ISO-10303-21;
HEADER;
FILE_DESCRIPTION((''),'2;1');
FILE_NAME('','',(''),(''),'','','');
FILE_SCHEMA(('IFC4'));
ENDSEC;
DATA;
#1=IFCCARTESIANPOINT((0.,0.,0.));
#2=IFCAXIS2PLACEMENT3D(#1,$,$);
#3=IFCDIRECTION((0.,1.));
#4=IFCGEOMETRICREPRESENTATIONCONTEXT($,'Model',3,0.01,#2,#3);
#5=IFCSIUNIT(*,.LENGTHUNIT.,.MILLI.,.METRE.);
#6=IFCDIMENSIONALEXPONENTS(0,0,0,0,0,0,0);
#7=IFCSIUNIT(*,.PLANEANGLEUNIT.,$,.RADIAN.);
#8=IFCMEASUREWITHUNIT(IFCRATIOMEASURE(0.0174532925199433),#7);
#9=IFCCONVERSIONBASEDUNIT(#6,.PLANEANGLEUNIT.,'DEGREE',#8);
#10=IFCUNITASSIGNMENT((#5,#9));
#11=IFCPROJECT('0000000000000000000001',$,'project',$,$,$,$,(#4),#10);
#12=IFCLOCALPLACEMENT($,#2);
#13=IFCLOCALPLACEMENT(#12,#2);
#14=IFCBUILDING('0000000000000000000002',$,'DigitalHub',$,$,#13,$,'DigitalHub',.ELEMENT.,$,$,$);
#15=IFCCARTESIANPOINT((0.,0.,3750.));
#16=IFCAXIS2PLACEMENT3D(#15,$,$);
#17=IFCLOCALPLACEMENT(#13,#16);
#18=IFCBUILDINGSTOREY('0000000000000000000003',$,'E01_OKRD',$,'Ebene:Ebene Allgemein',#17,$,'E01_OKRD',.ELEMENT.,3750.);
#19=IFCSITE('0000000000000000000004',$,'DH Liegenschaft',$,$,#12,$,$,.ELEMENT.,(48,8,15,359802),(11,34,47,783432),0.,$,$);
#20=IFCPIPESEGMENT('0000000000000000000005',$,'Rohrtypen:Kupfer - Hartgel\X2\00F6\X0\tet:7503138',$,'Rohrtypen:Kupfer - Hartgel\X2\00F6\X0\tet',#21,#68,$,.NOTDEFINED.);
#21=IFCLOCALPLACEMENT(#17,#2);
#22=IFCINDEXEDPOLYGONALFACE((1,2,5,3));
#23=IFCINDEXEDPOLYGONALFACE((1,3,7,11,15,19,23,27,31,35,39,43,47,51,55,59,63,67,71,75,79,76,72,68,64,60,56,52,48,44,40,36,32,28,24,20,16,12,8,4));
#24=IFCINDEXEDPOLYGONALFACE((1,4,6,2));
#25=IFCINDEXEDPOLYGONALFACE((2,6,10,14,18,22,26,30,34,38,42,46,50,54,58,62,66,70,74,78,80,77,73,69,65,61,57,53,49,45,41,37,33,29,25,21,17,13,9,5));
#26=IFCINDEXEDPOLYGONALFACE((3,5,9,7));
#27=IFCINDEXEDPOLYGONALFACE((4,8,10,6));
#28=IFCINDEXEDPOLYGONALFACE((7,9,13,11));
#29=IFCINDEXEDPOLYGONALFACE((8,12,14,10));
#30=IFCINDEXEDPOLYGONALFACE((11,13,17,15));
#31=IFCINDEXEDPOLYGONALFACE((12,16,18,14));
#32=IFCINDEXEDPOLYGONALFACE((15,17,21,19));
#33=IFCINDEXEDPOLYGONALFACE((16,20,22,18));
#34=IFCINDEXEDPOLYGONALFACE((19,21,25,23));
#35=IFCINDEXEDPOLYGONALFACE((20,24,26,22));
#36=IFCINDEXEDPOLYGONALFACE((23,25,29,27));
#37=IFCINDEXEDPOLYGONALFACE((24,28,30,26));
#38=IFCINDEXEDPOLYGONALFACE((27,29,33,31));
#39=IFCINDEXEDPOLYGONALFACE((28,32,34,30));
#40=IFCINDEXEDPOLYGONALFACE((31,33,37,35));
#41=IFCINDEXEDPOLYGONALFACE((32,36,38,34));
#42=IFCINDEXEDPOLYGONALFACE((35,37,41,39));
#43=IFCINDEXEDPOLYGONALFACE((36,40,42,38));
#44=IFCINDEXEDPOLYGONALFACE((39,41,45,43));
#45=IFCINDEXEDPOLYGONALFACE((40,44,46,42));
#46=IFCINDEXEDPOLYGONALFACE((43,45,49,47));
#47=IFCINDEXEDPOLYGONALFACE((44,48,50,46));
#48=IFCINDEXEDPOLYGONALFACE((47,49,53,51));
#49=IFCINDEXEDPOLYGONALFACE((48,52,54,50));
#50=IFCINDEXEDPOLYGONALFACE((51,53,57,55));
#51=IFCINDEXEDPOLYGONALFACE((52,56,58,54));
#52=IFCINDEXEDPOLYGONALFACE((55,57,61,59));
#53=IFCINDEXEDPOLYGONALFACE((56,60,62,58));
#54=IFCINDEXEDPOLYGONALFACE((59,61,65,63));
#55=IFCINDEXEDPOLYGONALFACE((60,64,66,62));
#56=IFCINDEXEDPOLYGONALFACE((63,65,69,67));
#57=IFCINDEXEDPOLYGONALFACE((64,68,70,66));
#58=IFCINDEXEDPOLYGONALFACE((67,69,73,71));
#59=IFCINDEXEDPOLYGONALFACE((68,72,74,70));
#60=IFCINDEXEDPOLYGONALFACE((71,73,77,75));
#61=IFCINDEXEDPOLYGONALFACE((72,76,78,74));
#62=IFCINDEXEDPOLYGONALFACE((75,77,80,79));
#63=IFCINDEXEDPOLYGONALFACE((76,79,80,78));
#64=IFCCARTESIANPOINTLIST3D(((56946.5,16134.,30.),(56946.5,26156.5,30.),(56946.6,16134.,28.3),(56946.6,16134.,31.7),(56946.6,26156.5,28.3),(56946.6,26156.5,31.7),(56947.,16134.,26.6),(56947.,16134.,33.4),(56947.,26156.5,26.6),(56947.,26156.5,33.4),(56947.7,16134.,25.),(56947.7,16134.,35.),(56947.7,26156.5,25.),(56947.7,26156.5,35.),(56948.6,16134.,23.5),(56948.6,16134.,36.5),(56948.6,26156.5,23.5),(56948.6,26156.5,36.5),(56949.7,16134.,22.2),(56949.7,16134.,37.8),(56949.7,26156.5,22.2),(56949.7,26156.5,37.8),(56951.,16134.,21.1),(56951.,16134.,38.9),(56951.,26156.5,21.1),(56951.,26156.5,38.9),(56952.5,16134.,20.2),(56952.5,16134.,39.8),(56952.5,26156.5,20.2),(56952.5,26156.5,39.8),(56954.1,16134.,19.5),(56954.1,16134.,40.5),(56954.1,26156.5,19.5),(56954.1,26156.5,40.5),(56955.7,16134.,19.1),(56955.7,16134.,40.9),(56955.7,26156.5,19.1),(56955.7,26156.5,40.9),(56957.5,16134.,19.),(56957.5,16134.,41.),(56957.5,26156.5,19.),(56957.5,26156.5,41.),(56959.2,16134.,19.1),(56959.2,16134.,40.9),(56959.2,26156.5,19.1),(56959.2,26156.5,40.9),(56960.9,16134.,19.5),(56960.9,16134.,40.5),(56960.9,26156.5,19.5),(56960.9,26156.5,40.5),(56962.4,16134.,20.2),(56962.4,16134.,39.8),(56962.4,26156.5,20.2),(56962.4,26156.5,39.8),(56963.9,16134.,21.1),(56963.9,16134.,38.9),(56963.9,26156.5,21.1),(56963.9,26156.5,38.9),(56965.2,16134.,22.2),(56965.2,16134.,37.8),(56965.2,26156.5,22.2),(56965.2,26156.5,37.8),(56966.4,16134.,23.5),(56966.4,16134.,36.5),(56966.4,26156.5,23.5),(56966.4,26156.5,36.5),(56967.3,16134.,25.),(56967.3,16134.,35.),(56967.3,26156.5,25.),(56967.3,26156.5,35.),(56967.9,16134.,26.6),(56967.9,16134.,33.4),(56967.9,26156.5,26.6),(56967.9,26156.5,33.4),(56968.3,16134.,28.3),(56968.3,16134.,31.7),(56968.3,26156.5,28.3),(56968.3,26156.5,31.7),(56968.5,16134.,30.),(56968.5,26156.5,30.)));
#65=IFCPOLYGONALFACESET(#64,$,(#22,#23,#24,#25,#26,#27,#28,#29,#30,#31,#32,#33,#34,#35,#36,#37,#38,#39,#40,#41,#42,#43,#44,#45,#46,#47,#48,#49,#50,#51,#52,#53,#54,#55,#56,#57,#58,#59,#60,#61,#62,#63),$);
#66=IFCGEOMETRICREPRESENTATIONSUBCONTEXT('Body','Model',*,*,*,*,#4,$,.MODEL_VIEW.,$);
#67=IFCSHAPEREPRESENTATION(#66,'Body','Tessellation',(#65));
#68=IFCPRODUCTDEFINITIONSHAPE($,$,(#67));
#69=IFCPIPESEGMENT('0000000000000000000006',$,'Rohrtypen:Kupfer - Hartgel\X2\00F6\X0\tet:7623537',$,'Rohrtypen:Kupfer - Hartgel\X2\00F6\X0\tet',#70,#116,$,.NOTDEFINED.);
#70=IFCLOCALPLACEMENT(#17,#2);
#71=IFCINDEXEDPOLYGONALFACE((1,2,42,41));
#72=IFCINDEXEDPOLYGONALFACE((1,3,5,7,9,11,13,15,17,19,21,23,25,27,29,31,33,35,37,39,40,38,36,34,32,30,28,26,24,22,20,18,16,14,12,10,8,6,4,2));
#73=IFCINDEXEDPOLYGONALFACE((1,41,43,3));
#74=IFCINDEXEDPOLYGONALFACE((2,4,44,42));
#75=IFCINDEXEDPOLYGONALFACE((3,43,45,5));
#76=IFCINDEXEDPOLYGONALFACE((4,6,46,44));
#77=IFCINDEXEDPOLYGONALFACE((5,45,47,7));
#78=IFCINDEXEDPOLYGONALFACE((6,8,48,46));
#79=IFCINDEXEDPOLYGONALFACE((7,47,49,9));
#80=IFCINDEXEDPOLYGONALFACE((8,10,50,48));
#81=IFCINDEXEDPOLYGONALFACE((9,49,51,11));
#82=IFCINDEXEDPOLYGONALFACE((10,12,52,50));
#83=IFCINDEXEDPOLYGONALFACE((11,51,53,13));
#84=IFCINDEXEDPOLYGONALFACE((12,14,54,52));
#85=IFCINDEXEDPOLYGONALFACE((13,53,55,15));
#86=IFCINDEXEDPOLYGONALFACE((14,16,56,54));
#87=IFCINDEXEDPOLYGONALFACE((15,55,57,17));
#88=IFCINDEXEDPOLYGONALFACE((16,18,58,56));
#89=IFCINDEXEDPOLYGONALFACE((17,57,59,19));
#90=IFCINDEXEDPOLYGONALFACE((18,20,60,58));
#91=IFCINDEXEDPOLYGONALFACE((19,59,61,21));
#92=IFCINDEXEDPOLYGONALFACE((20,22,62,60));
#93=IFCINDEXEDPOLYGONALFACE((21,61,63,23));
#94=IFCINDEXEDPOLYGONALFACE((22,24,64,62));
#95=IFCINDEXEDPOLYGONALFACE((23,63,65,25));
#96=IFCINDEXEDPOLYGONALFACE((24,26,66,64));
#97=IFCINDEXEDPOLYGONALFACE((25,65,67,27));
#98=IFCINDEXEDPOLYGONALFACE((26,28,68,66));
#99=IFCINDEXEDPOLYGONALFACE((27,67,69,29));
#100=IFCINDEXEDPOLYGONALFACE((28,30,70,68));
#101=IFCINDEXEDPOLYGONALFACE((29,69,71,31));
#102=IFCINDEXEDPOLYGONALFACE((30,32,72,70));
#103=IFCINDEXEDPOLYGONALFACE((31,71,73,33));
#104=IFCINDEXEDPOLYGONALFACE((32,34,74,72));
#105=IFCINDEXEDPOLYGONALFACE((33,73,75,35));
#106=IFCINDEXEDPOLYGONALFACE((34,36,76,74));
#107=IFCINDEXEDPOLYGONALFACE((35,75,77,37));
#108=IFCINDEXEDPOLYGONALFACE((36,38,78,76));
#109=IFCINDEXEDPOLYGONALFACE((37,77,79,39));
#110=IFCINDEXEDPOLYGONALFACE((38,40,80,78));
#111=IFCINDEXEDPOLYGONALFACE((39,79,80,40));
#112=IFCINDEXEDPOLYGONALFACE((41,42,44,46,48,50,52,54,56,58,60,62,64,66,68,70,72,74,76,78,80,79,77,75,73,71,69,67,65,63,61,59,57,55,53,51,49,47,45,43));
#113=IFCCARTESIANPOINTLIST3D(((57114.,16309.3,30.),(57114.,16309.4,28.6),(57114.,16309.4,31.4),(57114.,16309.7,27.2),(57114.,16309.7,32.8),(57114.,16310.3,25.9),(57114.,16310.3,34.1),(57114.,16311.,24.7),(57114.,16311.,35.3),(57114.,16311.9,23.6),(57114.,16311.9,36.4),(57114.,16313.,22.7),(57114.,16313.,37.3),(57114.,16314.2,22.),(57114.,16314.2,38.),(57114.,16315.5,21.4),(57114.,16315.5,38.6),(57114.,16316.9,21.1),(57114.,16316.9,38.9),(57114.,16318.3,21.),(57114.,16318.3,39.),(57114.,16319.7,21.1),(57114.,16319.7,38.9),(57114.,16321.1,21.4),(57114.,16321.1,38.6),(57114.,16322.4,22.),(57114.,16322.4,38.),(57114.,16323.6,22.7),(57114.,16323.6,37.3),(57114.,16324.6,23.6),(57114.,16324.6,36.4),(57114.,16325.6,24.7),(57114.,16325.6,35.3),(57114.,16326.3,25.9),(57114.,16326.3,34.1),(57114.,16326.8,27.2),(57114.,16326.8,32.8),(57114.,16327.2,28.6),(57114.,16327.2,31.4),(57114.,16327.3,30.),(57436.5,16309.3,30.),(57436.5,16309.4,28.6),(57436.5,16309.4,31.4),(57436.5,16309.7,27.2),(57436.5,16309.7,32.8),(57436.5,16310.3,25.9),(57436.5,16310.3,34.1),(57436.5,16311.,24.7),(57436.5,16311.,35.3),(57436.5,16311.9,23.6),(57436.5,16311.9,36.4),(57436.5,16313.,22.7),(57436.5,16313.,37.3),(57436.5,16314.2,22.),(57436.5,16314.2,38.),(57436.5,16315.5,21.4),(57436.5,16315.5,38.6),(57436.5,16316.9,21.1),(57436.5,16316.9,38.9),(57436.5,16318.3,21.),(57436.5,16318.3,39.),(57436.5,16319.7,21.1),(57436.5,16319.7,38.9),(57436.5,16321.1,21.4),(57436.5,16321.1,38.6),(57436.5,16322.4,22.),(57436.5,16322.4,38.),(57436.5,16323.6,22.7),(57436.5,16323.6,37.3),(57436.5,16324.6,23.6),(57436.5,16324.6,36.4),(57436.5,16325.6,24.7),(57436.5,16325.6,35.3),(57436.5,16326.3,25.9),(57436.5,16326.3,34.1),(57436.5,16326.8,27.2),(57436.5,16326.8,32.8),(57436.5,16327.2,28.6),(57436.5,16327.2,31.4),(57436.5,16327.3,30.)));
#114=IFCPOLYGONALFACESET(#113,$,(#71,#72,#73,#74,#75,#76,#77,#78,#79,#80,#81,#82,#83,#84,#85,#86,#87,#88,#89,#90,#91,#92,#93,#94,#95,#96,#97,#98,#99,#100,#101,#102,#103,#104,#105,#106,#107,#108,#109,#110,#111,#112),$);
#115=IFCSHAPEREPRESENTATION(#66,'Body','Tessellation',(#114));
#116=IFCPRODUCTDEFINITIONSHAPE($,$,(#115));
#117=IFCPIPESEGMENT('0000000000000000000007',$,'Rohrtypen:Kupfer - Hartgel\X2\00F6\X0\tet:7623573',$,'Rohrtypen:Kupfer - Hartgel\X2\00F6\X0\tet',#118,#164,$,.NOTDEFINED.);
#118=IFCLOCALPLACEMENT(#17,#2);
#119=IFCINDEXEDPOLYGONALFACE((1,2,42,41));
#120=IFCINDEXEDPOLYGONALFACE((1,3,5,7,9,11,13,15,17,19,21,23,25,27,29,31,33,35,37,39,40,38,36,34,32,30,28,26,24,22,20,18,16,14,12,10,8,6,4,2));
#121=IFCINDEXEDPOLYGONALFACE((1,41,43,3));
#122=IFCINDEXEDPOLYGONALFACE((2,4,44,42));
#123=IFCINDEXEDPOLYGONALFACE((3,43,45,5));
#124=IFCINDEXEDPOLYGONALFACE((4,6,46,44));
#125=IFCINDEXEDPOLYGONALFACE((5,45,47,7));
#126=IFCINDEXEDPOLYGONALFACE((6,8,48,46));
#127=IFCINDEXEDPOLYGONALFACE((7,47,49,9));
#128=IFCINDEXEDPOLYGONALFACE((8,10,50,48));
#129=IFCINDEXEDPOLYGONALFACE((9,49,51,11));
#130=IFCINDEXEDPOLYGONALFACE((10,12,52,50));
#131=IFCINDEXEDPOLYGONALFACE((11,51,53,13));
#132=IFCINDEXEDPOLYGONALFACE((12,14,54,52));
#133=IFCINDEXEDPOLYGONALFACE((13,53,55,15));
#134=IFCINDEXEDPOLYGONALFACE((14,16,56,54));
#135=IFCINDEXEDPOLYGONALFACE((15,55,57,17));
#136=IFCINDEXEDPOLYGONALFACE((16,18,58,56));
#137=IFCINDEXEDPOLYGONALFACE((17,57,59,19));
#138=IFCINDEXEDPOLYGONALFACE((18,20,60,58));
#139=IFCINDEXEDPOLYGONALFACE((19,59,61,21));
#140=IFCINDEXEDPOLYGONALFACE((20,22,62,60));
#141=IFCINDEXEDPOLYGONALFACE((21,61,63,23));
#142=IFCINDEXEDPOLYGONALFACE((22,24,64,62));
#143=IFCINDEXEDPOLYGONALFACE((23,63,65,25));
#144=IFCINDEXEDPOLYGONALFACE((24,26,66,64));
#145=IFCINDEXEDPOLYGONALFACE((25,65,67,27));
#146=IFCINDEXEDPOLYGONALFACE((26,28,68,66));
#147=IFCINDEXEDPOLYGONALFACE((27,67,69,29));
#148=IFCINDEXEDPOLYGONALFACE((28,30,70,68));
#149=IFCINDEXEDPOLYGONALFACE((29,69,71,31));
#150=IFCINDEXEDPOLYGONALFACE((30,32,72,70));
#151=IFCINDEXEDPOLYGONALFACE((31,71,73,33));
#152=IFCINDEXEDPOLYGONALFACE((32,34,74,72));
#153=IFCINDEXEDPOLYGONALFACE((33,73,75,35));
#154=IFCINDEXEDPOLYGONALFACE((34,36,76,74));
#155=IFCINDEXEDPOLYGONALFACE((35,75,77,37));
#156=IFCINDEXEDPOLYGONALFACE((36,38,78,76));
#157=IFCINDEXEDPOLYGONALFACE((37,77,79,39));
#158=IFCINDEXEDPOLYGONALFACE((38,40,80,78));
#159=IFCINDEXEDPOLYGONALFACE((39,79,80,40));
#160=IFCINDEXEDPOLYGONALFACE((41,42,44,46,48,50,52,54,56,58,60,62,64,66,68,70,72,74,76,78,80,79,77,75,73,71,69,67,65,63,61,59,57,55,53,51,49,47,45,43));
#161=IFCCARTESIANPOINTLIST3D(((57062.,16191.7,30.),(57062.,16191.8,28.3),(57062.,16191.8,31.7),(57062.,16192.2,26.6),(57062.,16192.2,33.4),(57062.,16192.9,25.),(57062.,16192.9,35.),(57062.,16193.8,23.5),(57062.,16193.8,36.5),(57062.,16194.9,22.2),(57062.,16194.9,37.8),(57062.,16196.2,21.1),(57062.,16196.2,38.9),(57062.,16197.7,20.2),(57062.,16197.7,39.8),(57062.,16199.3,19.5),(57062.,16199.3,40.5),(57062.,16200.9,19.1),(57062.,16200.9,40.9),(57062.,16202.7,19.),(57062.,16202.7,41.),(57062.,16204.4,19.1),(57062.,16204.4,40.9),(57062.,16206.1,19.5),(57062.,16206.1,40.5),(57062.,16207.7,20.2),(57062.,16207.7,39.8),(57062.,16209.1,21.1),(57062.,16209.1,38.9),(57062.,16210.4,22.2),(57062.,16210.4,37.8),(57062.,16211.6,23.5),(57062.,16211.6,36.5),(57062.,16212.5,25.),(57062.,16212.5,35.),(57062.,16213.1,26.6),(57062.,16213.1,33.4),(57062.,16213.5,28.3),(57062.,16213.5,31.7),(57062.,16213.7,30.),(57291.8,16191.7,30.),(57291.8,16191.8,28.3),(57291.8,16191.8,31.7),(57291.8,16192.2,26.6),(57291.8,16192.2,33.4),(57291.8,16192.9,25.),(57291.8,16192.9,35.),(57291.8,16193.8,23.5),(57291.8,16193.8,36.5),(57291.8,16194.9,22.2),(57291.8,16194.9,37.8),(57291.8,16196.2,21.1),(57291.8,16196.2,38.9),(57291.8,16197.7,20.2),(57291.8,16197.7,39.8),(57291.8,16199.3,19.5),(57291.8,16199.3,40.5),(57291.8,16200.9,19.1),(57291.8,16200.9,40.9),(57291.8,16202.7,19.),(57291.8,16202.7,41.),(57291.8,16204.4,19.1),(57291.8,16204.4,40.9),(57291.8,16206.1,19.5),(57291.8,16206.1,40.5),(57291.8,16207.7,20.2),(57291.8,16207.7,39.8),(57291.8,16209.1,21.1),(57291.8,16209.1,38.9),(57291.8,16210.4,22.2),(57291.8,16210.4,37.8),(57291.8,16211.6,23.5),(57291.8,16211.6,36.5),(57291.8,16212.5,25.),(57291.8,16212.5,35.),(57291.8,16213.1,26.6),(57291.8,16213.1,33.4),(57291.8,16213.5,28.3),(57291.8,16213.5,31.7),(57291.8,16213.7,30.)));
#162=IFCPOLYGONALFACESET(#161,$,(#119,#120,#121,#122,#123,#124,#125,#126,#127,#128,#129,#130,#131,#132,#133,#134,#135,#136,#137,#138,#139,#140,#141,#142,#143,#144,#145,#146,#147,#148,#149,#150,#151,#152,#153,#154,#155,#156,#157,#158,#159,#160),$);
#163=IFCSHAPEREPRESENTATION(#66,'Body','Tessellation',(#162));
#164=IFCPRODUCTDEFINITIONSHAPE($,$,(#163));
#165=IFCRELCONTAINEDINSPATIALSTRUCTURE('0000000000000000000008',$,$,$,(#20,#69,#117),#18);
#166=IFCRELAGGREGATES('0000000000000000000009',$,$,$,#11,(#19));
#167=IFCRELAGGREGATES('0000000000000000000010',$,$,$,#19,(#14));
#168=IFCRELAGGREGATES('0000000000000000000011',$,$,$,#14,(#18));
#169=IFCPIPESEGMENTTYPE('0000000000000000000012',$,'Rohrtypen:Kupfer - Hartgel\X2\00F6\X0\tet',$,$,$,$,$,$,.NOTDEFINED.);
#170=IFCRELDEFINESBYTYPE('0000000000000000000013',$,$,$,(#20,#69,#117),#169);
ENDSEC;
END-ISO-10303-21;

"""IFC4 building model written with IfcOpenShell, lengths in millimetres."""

from ifc_helpers import new_model, entity, si_unit, converted_unit, direction, frame, origin, place, context, subcontext, project, spatial, indexed_curve, outline, extrude, type_object, element, save


model = new_model("IFC4")

# Units and contexts
model_context = context("Model", 3, precision=0.01, world=origin(), true_north=direction((0.0, 1.0)))
body_context = subcontext(model_context, "Body", "Model", "MODEL_VIEW")
ifc_project = project(units=[si_unit("LENGTHUNIT", "METRE", prefix="MILLI"), converted_unit("PLANEANGLEUNIT", "DEGREE", entity("IfcRatioMeasure", 0.0174532925199433), si_unit("PLANEANGLEUNIT", "RADIAN"), dimensions=[0, 0, 0, 0, 0, 0, 0])], contexts=[model_context])

# Site, building, storey
site_placement = place(None, origin())
site = spatial("IfcSite", under=ifc_project, at=site_placement, Name="DH Liegenschaft", CompositionType="ELEMENT", RefLatitude=(48, 8, 15, 359802), RefLongitude=(11, 34, 47, 783432), RefElevation=0.0)
building_placement = place(site_placement, origin())
building = spatial("IfcBuilding", under=site, at=building_placement, Name="DigitalHub", LongName="DigitalHub", CompositionType="ELEMENT")
storey_placement = place(building_placement, frame((0.0, 0.0, 3750.0)))
storey = spatial("IfcBuildingStorey", under=building, at=storey_placement, Name="E01_OKRD", ObjectType="Ebene:Ebene Allgemein", LongName="E01_OKRD", CompositionType="ELEMENT", Elevation=3750.0)

# Pipe segments
pipe_segment_type = type_object("IfcPipeSegmentType", Name="Rohrtypen:Kupfer - Hartgelötet", PredefinedType="NOTDEFINED")
pipe_segment_1_placement = place(storey_placement, frame((56944.9, 16134.0, 17.4)))
element("IfcPipeSegment", 1, at=pipe_segment_1_placement, inside=storey, type_object=pipe_segment_type, Name="Rohrtypen:Kupfer - Hartgelötet:7503138", ObjectType="Rohrtypen:Kupfer - Hartgelötet", PredefinedType="NOTDEFINED", context=body_context, shape_type="SweptSolid", body=[
    extrude(outline(indexed_curve([(11.0, 0.0), (10.9, 1.7), (10.5, 3.4), (9.8, 5.0), (8.9, 6.5), (7.8, 7.8), (6.5, 8.9), (5.0, 9.8), (3.4, 10.5), (1.7, 10.9), (0.0, 11.0), (-1.7, 10.9), (-3.4, 10.5), (-5.0, 9.8), (-6.5, 8.9), (-7.8, 7.8), (-8.9, 6.5), (-9.8, 5.0), (-10.5, 3.4), (-10.9, 1.7), (-11.0, 0.0), (-10.9, -1.7), (-10.5, -3.4), (-9.8, -5.0), (-8.9, -6.5), (-7.8, -7.8), (-6.5, -8.9), (-5.0, -9.8), (-3.4, -10.5), (-1.7, -10.9), (0.0, -11.0), (1.7, -10.9), (3.4, -10.5), (5.0, -9.8), (6.5, -8.9), (7.8, -7.8), (8.9, -6.5), (9.8, -5.0), (10.5, -3.4), (10.9, -1.7), (11.0, 0.0)], self_intersect=False)), frame((12.6, 0.0, 12.6), z_axis=(0.0, 1.0, 0.0), x_axis=(-1.0, 0.0, 0.0)), (0.0, 0.0, 1.0), 10022.5),
])
pipe_segment_2_placement = place(storey_placement, frame((57114.0, 16307.7, 19.4)))
element("IfcPipeSegment", 2, at=pipe_segment_2_placement, inside=storey, type_object=pipe_segment_type, Name="Rohrtypen:Kupfer - Hartgelötet:7623537", ObjectType="Rohrtypen:Kupfer - Hartgelötet", PredefinedType="NOTDEFINED", context=body_context, shape_type="SweptSolid", body=[
    extrude(outline(indexed_curve([(9.0, 0.0), (8.9, 1.4), (8.6, 2.8), (8.0, 4.1), (7.3, 5.3), (6.4, 6.4), (5.3, 7.3), (4.1, 8.0), (2.8, 8.6), (1.4, 8.9), (0.0, 9.0), (-1.4, 8.9), (-2.8, 8.6), (-4.1, 8.0), (-5.3, 7.3), (-6.4, 6.4), (-7.3, 5.3), (-8.0, 4.1), (-8.6, 2.8), (-8.9, 1.4), (-9.0, 0.0), (-8.9, -1.4), (-8.6, -2.8), (-8.0, -4.1), (-7.3, -5.3), (-6.4, -6.4), (-5.3, -7.3), (-4.1, -8.0), (-2.8, -8.6), (-1.4, -8.9), (0.0, -9.0), (1.4, -8.9), (2.8, -8.6), (4.1, -8.0), (5.3, -7.3), (6.4, -6.4), (7.3, -5.3), (8.0, -4.1), (8.6, -2.8), (8.9, -1.4), (9.0, 0.0)], self_intersect=False)), frame((0.0, 10.6, 10.6), z_axis=(1.0, 0.0, 0.0), x_axis=(0.0, 1.0, 0.0)), (0.0, 0.0, 1.0), 322.6),
])
pipe_segment_3_placement = place(storey_placement, frame((57062.0, 16190.1, 17.4)))
element("IfcPipeSegment", 3, at=pipe_segment_3_placement, inside=storey, type_object=pipe_segment_type, Name="Rohrtypen:Kupfer - Hartgelötet:7623573", ObjectType="Rohrtypen:Kupfer - Hartgelötet", PredefinedType="NOTDEFINED", context=body_context, shape_type="SweptSolid", body=[
    extrude(outline(indexed_curve([(11.0, 0.0), (10.9, 1.7), (10.5, 3.4), (9.8, 5.0), (8.9, 6.5), (7.8, 7.8), (6.5, 8.9), (5.0, 9.8), (3.4, 10.5), (1.7, 10.9), (0.0, 11.0), (-1.7, 10.9), (-3.4, 10.5), (-5.0, 9.8), (-6.5, 8.9), (-7.8, 7.8), (-8.9, 6.5), (-9.8, 5.0), (-10.5, 3.4), (-10.9, 1.7), (-11.0, 0.0), (-10.9, -1.7), (-10.5, -3.4), (-9.8, -5.0), (-8.9, -6.5), (-7.8, -7.8), (-6.5, -8.9), (-5.0, -9.8), (-3.4, -10.5), (-1.7, -10.9), (0.0, -11.0), (1.7, -10.9), (3.4, -10.5), (5.0, -9.8), (6.5, -8.9), (7.8, -7.8), (8.9, -6.5), (9.8, -5.0), (10.5, -3.4), (10.9, -1.7), (11.0, 0.0)], self_intersect=False)), frame((0.0, 12.6, 12.6), z_axis=(1.0, 0.0, 0.0), x_axis=(0.0, 1.0, 0.0)), (0.0, 0.0, 1.0), 229.9),
])

save(model, "model.ifc")
